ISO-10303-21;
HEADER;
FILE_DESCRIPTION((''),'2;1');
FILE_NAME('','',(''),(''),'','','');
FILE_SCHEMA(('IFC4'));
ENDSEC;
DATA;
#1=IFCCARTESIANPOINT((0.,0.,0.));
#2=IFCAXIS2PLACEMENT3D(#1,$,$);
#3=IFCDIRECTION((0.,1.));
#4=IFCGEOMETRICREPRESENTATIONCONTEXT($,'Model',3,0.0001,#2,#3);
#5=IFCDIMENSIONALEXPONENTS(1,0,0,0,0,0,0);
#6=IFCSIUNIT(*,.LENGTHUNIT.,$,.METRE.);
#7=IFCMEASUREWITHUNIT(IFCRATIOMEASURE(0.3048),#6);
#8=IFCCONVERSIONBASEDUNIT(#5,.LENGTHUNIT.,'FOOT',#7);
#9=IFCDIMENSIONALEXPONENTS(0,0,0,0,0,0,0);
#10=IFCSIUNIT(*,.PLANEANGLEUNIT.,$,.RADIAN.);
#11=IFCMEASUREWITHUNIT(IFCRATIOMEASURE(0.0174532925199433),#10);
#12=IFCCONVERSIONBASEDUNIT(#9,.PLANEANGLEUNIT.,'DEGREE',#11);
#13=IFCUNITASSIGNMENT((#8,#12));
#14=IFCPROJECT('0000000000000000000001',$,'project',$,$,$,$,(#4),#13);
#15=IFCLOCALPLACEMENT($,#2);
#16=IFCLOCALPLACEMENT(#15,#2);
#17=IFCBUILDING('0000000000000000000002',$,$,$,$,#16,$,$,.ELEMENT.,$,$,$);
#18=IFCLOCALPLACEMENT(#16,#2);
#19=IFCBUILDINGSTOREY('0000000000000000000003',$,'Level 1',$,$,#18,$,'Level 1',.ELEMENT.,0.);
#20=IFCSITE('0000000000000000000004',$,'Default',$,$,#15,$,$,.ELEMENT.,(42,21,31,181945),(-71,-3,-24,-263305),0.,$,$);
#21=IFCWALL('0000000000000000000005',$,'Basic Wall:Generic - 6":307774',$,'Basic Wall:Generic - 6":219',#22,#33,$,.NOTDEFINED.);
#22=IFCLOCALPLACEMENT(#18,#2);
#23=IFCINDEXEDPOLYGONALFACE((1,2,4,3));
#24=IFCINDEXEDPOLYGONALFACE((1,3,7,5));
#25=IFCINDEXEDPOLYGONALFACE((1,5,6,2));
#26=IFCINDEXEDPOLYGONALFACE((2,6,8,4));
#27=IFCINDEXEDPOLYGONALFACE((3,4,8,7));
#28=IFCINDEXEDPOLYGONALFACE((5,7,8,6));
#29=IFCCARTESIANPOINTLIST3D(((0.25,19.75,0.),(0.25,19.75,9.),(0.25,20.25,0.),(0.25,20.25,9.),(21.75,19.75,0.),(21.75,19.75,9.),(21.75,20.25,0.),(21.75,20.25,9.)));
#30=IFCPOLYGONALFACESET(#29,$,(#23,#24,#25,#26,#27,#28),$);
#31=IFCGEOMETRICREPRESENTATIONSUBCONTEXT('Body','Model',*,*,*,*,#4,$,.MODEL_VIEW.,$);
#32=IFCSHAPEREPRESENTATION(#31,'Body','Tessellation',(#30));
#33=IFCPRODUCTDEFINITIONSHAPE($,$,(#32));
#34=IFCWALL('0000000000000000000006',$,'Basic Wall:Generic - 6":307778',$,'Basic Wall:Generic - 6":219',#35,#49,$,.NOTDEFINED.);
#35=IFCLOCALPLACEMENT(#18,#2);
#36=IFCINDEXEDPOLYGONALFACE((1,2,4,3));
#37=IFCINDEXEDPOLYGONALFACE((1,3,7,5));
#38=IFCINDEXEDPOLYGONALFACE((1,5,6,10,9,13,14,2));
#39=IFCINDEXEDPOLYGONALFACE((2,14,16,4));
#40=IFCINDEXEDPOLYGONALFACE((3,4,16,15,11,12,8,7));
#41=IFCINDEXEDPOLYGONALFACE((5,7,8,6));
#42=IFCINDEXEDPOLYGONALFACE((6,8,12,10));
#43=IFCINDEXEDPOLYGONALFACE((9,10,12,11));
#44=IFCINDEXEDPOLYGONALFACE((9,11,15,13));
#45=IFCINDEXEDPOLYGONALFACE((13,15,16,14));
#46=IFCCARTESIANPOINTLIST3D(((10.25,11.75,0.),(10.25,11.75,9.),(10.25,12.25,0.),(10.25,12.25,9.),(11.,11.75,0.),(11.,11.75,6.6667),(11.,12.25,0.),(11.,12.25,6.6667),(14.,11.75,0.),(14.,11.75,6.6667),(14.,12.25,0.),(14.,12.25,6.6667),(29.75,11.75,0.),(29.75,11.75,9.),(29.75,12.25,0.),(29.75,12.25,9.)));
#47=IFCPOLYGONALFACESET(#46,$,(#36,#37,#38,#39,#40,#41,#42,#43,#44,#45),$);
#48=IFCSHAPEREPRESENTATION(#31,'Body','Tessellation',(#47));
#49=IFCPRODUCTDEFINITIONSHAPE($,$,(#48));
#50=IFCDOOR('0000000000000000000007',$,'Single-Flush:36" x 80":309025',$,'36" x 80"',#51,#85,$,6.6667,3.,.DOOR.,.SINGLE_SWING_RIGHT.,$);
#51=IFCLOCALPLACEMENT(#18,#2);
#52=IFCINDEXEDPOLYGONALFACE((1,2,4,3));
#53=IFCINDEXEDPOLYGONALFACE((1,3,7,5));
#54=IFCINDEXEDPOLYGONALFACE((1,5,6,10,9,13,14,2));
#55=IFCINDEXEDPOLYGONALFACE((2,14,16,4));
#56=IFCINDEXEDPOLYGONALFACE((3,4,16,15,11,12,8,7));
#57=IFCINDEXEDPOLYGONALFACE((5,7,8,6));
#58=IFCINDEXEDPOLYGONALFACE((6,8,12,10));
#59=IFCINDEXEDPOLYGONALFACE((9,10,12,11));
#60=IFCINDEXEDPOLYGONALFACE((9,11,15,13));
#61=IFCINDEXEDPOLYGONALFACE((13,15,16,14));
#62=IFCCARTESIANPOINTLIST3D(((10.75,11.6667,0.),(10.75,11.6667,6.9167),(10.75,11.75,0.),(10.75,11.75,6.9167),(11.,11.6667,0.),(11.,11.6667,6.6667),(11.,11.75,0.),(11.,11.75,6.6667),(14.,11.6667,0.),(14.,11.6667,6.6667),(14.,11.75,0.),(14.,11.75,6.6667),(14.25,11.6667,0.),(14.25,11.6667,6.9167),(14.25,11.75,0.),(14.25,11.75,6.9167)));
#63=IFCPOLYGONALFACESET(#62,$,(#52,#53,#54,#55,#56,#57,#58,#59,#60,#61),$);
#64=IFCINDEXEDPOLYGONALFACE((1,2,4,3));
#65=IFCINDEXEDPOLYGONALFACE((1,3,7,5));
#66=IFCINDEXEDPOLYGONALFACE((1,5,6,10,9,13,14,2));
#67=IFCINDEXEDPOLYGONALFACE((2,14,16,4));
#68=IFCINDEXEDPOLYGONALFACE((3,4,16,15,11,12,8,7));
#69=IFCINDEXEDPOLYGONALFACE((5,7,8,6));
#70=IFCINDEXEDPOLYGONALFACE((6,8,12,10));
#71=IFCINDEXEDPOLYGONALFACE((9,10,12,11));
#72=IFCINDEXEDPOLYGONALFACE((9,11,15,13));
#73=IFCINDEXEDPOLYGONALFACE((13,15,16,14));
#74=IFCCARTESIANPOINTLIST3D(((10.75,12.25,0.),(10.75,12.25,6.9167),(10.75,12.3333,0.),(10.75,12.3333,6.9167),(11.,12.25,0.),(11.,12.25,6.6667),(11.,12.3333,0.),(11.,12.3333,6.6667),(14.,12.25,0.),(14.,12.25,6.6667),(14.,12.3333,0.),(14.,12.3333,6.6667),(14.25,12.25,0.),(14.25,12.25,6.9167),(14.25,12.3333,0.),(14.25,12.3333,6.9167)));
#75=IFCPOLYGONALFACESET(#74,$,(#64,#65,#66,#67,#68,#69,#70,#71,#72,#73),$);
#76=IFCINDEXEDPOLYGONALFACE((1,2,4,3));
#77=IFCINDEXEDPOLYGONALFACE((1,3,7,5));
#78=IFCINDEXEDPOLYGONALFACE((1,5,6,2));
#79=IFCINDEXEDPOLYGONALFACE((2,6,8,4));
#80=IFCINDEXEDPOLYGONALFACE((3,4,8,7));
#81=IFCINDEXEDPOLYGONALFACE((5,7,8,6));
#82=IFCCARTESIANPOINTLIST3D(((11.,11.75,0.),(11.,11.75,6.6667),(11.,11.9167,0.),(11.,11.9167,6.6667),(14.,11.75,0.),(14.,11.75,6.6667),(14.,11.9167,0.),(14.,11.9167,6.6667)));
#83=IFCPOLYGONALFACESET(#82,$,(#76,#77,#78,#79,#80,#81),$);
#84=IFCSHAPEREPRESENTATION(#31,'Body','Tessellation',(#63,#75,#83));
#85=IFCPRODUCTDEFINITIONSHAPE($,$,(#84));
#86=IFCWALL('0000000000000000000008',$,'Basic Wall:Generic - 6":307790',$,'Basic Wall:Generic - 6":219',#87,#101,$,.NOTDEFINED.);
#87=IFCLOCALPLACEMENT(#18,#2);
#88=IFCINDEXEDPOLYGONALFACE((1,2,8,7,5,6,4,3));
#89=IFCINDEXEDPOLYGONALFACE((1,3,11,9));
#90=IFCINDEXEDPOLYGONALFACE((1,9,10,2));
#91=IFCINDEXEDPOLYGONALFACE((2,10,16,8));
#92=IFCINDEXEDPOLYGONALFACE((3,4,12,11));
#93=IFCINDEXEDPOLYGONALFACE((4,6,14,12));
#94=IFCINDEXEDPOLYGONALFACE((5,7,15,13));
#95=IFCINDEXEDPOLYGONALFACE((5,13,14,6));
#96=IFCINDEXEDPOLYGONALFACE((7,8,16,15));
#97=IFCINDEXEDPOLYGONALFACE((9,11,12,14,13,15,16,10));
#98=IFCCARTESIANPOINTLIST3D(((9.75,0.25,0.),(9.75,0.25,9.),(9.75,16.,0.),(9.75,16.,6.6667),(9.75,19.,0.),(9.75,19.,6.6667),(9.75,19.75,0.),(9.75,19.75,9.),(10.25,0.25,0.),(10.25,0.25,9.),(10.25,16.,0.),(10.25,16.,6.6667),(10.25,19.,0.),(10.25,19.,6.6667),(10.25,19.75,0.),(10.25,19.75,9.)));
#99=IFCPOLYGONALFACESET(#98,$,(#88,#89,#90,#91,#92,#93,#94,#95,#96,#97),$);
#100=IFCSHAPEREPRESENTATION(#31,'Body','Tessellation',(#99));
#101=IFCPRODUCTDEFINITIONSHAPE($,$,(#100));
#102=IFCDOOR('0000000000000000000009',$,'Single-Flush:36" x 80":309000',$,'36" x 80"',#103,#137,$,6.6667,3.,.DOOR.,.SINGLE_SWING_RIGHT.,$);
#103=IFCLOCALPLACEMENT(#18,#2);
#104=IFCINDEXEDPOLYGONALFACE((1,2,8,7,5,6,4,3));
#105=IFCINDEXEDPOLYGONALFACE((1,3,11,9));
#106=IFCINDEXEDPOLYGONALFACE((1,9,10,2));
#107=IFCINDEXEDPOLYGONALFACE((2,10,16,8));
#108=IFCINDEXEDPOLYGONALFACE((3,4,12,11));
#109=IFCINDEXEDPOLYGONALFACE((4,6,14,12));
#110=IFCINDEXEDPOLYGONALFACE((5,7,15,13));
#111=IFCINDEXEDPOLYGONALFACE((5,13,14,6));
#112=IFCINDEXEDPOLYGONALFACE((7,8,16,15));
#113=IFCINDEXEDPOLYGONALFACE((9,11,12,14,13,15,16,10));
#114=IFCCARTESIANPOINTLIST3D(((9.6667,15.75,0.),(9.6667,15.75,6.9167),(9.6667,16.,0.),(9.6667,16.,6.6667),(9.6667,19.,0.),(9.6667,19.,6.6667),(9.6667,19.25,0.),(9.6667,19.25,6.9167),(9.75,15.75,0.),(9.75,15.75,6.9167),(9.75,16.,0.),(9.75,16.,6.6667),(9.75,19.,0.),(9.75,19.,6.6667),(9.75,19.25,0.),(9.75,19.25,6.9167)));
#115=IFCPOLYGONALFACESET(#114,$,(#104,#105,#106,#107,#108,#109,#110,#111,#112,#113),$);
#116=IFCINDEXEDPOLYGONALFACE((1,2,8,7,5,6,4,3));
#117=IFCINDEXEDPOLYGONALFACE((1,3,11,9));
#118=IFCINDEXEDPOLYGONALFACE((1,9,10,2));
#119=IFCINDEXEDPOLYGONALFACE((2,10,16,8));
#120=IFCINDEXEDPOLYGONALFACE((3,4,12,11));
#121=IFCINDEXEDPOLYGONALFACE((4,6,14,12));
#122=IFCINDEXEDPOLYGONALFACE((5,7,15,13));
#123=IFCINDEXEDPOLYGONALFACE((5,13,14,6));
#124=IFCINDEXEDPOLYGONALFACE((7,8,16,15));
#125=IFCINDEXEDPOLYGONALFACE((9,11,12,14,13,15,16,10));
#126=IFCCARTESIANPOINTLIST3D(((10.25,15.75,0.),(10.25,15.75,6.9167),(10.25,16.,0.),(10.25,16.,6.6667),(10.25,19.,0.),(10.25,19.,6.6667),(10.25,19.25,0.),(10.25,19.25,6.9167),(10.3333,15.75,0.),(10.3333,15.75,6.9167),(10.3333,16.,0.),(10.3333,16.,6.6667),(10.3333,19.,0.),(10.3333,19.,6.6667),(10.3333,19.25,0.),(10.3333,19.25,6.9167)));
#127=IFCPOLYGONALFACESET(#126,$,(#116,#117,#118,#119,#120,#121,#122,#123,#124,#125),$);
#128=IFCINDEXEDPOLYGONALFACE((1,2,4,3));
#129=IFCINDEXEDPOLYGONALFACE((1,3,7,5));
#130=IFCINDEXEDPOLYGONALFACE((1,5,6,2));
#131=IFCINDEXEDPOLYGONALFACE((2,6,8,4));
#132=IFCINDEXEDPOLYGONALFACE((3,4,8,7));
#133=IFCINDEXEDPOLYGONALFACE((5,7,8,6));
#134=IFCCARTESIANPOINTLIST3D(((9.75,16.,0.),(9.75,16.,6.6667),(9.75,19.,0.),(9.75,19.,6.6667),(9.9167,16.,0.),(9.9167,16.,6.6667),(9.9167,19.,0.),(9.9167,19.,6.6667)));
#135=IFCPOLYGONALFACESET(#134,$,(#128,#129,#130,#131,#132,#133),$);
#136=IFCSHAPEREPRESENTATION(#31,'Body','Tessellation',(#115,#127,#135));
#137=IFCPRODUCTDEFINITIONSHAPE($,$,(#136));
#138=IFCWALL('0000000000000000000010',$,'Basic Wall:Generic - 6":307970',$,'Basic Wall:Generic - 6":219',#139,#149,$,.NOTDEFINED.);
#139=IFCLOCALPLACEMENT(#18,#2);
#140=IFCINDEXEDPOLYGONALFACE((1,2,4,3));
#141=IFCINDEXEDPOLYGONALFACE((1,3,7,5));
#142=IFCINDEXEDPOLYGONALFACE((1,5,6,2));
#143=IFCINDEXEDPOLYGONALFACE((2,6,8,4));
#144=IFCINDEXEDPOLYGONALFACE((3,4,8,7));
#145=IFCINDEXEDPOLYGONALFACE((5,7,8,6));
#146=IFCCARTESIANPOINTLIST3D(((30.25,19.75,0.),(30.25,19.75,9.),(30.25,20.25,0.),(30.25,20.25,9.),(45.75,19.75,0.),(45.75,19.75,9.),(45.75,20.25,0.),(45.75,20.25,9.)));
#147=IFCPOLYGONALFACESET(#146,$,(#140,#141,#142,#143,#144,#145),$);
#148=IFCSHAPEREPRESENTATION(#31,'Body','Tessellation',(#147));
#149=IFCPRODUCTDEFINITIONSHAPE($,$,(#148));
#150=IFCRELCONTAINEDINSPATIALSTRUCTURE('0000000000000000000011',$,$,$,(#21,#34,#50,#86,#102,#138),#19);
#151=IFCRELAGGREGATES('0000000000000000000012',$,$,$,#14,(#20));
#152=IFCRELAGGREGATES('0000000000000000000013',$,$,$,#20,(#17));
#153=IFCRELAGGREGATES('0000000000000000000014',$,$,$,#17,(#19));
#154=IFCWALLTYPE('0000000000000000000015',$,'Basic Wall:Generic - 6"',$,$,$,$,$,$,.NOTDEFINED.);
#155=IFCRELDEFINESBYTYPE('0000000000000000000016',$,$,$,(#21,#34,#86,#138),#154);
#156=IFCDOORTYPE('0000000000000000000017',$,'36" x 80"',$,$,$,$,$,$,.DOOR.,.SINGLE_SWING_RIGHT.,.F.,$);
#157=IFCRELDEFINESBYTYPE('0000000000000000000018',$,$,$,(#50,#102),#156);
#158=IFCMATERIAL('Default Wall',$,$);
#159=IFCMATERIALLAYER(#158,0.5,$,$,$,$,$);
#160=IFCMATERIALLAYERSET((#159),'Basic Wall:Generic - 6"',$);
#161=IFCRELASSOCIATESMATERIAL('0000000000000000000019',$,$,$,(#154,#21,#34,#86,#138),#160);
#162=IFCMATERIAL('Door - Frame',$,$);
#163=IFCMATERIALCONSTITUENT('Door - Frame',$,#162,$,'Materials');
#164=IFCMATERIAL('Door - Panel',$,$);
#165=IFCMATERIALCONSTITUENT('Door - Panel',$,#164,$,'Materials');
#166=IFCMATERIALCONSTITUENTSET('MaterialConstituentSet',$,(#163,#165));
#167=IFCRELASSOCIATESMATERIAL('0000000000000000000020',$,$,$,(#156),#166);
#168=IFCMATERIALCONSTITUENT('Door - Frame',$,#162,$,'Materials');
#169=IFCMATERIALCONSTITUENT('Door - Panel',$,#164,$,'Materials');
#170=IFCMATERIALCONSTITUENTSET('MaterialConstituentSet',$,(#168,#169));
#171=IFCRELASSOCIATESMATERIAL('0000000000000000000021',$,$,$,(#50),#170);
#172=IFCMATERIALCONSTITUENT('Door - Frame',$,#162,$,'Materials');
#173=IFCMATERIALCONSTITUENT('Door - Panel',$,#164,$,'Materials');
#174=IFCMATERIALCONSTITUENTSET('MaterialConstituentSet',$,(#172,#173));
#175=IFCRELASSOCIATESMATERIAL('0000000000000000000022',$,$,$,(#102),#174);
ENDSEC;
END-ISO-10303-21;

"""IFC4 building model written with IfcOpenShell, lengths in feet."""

from ifc_helpers import new_model, entity, si_unit, converted_unit, direction, frame, frame_2d, origin, origin_2d_with_axis, place, context, subcontext, project, spatial, polyline, rectangle, outline, extrude, clip, bounded_halfspace, source, transform, mapped, material, layer, layer_set, layer_usage, constituent, constituent_set, type_object, type_shapes, element, fill, save


model = new_model("IFC4")

# Units and contexts
model_context = context("Model", 3, precision=0.0001, world=origin(), true_north=direction((0.0, 1.0)))
body_context = subcontext(model_context, "Body", "Model", "MODEL_VIEW")
ifc_project = project(units=[converted_unit("LENGTHUNIT", "FOOT", entity("IfcRatioMeasure", 0.3048), si_unit("LENGTHUNIT", "METRE"), dimensions=[1, 0, 0, 0, 0, 0, 0]), converted_unit("PLANEANGLEUNIT", "DEGREE", entity("IfcRatioMeasure", 0.0174532925199433), si_unit("PLANEANGLEUNIT", "RADIAN"), dimensions=[0, 0, 0, 0, 0, 0, 0])], contexts=[model_context])

# Site, building, storey
site_placement = place(None, origin())
site = spatial("IfcSite", under=ifc_project, at=site_placement, Name="Default", CompositionType="ELEMENT", RefLatitude=(42, 21, 31, 181945), RefLongitude=(-71, -3, -24, -263305), RefElevation=0.0)
building_placement = place(site_placement, origin())
building = spatial("IfcBuilding", under=site, at=building_placement, CompositionType="ELEMENT")
storey_placement = place(building_placement, origin())
storey = spatial("IfcBuildingStorey", under=building, at=storey_placement, Name="Level 1", LongName="Level 1", CompositionType="ELEMENT", Elevation=0.0)

# Shared definitions
ifc_material_1 = material(Name="Default Wall")
ifc_layer = layer(ifc_material_1, 0.5)
ifc_layer_set = layer_set([ifc_layer], Name="Basic Wall:Generic - 6\"")
wall_type = type_object("IfcWallType", Name="Basic Wall:Generic - 6\"", PredefinedType="NOTDEFINED", material=ifc_layer_set)

# Wall
ifc_layer_usage_1 = layer_usage(ifc_layer_set, "AXIS2", "NEGATIVE", 0.25)
wall_1_placement = place(storey_placement, frame((0.25, 20.0, 0.0)))
element("IfcWall", 1, at=wall_1_placement, inside=storey, type_object=wall_type, material=ifc_layer_usage_1, Name="Basic Wall:Generic - 6\":307774", ObjectType="Basic Wall:Generic - 6\":219", PredefinedType="NOTDEFINED", context=body_context, shape_type="Clipping", body=[
    clip(clip(extrude(rectangle(XDim=21.5, YDim=0.5, at=frame_2d((10.75, 0.0), x_axis=(-1.0, 0.0))), origin(), (0.0, 0.0, 1.0), 9.0), bounded_halfspace(frame((21.5, -0.25, 9.0), z_axis=(0.0, 0.0, -1.0), x_axis=(0.0, 1.0, 0.0)), True, frame((21.5, -0.25, 9.0)), polyline([(0.0, 0.0), (0.0, 0.5), (-12.0, 0.5), (-12.0, 0.0), (-11.5, 0.0), (0.0, 0.0)]))), bounded_halfspace(frame((0.0, -0.25, 9.0), z_axis=(0.0, 0.0, -1.0), x_axis=(0.0, -1.0, 0.0)), True, frame((0.0, -0.25, 9.0)), polyline([(0.0, 0.0), (9.5, 0.0), (9.5, 0.5), (0.0, 0.5), (0.0, 0.0)]))),
])

# Walls, openings, doors
ifc_layer_usage_2 = layer_usage(ifc_layer_set, "AXIS2", "NEGATIVE", 0.25)
wall_2_placement = place(storey_placement, frame((10.25, 12.0, 0.0)))
wall_2 = element("IfcWall", 2, at=wall_2_placement, inside=storey, type_object=wall_type, material=ifc_layer_usage_2, Name="Basic Wall:Generic - 6\":307778", ObjectType="Basic Wall:Generic - 6\":219", PredefinedType="NOTDEFINED", context=body_context, shape_type="Clipping", body=[
    clip(extrude(rectangle(XDim=19.5, YDim=0.5, at=frame_2d((9.75, 0.0), x_axis=(-1.0, 0.0))), origin(), (0.0, 0.0, 1.0), 9.0), bounded_halfspace(frame((0.0, -0.25, 9.0), z_axis=(0.0, 0.0, -1.0), x_axis=(1.0, 0.0, 0.0)), True, frame((0.0, -0.25, 9.0)), polyline([(0.0, 0.0), (19.5, 0.0), (19.5, 0.5), (0.0, 0.5), (0.0, 0.0)]))),
])
opening_1_placement = place(wall_2_placement, frame((3.75, 0.25, 0.0)))
opening_1 = element("IfcOpeningElement", 3, at=opening_1_placement, cuts=wall_2, ObjectType="Opening", PredefinedType="OPENING", context=body_context, shape_type="SweptSolid", body=[
    extrude(rectangle(XDim=3.0, YDim=6.6667, at=frame_2d((3.3333, 1.5), x_axis=(0.0, 1.0))), frame((0.0, 0.0, 0.0), z_axis=(0.0, -1.0, 0.0), x_axis=(0.0, 0.0, 1.0)), (0.0, 0.0, 1.0), 0.5),
])
ifc_material_2 = material(Name="Door - Frame")
ifc_constituent_1 = constituent(ifc_material_2, Name="Door - Frame", Category="Materials")
ifc_material_3 = material(Name="Door - Panel")
ifc_constituent_2 = constituent(ifc_material_3, Name="Door - Panel", Category="Materials")
ifc_constituent_set_1 = constituent_set(constituents=[ifc_constituent_1, ifc_constituent_2], Name="MaterialConstituentSet")
ifc_constituent_3 = constituent(ifc_material_2, Name="Door - Frame", Category="Materials")
ifc_constituent_4 = constituent(ifc_material_3, Name="Door - Panel", Category="Materials")
ifc_constituent_set_2 = constituent_set(constituents=[ifc_constituent_3, ifc_constituent_4], Name="MaterialConstituentSet")
door_type = type_object("IfcDoorType", Name="36\" x 80\"", OperationType="SINGLE_SWING_RIGHT", ParameterTakesPrecedence=False, PredefinedType="DOOR", material=ifc_constituent_set_2)
shared_shape_1 = source(origin(), body_context, "Body", "SweptSolid", [
    extrude(outline(polyline([(-1.75, -3.5208), (1.75, -3.5208), (1.75, 3.3958), (1.5, 3.3958), (1.5, -3.2708), (-1.5, -3.2708), (-1.5, 3.3958), (-1.75, 3.3958), (-1.75, -3.5208)])), frame((1.5, 0.5, 3.3958), z_axis=(0.0, 1.0, 0.0), x_axis=(1.0, 0.0, 0.0)), (0.0, 0.0, 1.0), 0.0833),
    extrude(outline(polyline([(-3.5208, -1.75), (3.3958, -1.75), (3.3958, -1.5), (-3.2708, -1.5), (-3.2708, 1.5), (3.3958, 1.5), (3.3958, 1.75), (-3.5208, 1.75), (-3.5208, -1.75)])), frame((1.5, -0.0833, 3.3958), z_axis=(0.0, 1.0, 0.0), x_axis=(0.0, 0.0, -1.0)), (0.0, 0.0, 1.0), 0.0833),
    extrude(rectangle(XDim=0.1667, YDim=3.0, at=origin_2d_with_axis()), frame((1.5, 0.4167, 0.0), z_axis=(0.0, 0.0, 1.0), x_axis=(0.0, 1.0, 0.0)), (0.0, 0.0, 1.0), 6.6667),
])
type_shapes(door_type, [shared_shape_1])
door_1_placement = place(opening_1_placement, frame((0.0, 0.0, 0.0), z_axis=(0.0, 0.0, 1.0), x_axis=(-1.0, 0.0, 0.0)))
door_1 = element("IfcDoor", 4, at=door_1_placement, inside=storey, type_object=door_type, material=ifc_constituent_set_1, Name="Single-Flush:36\" x 80\":309025", ObjectType="36\" x 80\"", OperationType="SINGLE_SWING_RIGHT", OverallHeight=6.6667, OverallWidth=3.0, PredefinedType="DOOR", context=body_context, shape_type="MappedRepresentation", body=[
    mapped(shared_shape_1, transform((0.0, 0.0, 0.0), scale=1.0)),
])
fill(opening_1, door_1)
ifc_layer_usage_3 = layer_usage(ifc_layer_set, "AXIS2", "NEGATIVE", 0.25)
wall_3_placement = place(storey_placement, frame((10.0, 19.75, 0.0), z_axis=(0.0, 0.0, 1.0), x_axis=(0.0, -1.0, 0.0)))
wall_3 = element("IfcWall", 5, at=wall_3_placement, inside=storey, type_object=wall_type, material=ifc_layer_usage_3, Name="Basic Wall:Generic - 6\":307790", ObjectType="Basic Wall:Generic - 6\":219", PredefinedType="NOTDEFINED", context=body_context, shape_type="Clipping", body=[
    clip(extrude(rectangle(XDim=19.5, YDim=0.5, at=frame_2d((9.75, 0.0), x_axis=(-1.0, 0.0))), origin(), (0.0, 0.0, 1.0), 9.0), bounded_halfspace(frame((7.5, -0.25, 9.0), z_axis=(0.0, 0.0, -1.0), x_axis=(0.0, 1.0, 0.0)), True, frame((7.5, -0.25, 9.0)), polyline([(0.0, 0.0), (12.0, 0.0), (12.0, 0.5), (0.5, 0.5), (0.0, 0.5), (-7.5, 0.5), (-7.5, 0.0), (0.0, 0.0)]))),
])
opening_2_placement = place(wall_3_placement, frame((3.75, 0.25, 0.0)))
opening_2 = element("IfcOpeningElement", 6, at=opening_2_placement, cuts=wall_3, ObjectType="Opening", PredefinedType="OPENING", context=body_context, shape_type="SweptSolid", body=[
    extrude(rectangle(XDim=3.0, YDim=6.6667, at=frame_2d((3.3333, 1.5), x_axis=(0.0, 1.0))), frame((0.0, 0.0, 0.0), z_axis=(0.0, -1.0, 0.0), x_axis=(0.0, 0.0, 1.0)), (0.0, 0.0, 1.0), 0.5),
])
ifc_constituent_5 = constituent(ifc_material_2, Name="Door - Frame", Category="Materials")
ifc_constituent_6 = constituent(ifc_material_3, Name="Door - Panel", Category="Materials")
ifc_constituent_set_3 = constituent_set(constituents=[ifc_constituent_5, ifc_constituent_6], Name="MaterialConstituentSet")
door_2_placement = place(opening_2_placement, frame((0.0, 0.0, 0.0), z_axis=(0.0, 0.0, 1.0), x_axis=(-1.0, 0.0, 0.0)))
door_2 = element("IfcDoor", 7, at=door_2_placement, inside=storey, type_object=door_type, material=ifc_constituent_set_3, Name="Single-Flush:36\" x 80\":309000", ObjectType="36\" x 80\"", OperationType="SINGLE_SWING_RIGHT", OverallHeight=6.6667, OverallWidth=3.0, PredefinedType="DOOR", context=body_context, shape_type="MappedRepresentation", body=[
    mapped(shared_shape_1, transform((0.0, 0.0, 0.0), scale=1.0)),
])
fill(opening_2, door_2)

# Wall
ifc_layer_usage_4 = layer_usage(ifc_layer_set, "AXIS2", "NEGATIVE", 0.25)
wall_4_placement = place(storey_placement, frame((30.25, 20.0, 0.0)))
element("IfcWall", 8, at=wall_4_placement, inside=storey, type_object=wall_type, material=ifc_layer_usage_4, Name="Basic Wall:Generic - 6\":307970", ObjectType="Basic Wall:Generic - 6\":219", PredefinedType="NOTDEFINED", context=body_context, shape_type="Clipping", body=[
    clip(extrude(rectangle(XDim=15.5, YDim=0.5, at=frame_2d((7.75, 0.0), x_axis=(-1.0, 0.0))), origin(), (0.0, 0.0, 1.0), 9.0), bounded_halfspace(frame((0.0, -0.25, 9.0), z_axis=(0.0, 0.0, -1.0), x_axis=(1.0, 0.0, 0.0)), True, frame((0.0, -0.25, 9.0)), polyline([(0.0, 0.0), (15.5, 0.0), (15.5, 0.5), (0.0, 0.5), (0.0, 0.0)]))),
])

save(model, "model.ifc")
